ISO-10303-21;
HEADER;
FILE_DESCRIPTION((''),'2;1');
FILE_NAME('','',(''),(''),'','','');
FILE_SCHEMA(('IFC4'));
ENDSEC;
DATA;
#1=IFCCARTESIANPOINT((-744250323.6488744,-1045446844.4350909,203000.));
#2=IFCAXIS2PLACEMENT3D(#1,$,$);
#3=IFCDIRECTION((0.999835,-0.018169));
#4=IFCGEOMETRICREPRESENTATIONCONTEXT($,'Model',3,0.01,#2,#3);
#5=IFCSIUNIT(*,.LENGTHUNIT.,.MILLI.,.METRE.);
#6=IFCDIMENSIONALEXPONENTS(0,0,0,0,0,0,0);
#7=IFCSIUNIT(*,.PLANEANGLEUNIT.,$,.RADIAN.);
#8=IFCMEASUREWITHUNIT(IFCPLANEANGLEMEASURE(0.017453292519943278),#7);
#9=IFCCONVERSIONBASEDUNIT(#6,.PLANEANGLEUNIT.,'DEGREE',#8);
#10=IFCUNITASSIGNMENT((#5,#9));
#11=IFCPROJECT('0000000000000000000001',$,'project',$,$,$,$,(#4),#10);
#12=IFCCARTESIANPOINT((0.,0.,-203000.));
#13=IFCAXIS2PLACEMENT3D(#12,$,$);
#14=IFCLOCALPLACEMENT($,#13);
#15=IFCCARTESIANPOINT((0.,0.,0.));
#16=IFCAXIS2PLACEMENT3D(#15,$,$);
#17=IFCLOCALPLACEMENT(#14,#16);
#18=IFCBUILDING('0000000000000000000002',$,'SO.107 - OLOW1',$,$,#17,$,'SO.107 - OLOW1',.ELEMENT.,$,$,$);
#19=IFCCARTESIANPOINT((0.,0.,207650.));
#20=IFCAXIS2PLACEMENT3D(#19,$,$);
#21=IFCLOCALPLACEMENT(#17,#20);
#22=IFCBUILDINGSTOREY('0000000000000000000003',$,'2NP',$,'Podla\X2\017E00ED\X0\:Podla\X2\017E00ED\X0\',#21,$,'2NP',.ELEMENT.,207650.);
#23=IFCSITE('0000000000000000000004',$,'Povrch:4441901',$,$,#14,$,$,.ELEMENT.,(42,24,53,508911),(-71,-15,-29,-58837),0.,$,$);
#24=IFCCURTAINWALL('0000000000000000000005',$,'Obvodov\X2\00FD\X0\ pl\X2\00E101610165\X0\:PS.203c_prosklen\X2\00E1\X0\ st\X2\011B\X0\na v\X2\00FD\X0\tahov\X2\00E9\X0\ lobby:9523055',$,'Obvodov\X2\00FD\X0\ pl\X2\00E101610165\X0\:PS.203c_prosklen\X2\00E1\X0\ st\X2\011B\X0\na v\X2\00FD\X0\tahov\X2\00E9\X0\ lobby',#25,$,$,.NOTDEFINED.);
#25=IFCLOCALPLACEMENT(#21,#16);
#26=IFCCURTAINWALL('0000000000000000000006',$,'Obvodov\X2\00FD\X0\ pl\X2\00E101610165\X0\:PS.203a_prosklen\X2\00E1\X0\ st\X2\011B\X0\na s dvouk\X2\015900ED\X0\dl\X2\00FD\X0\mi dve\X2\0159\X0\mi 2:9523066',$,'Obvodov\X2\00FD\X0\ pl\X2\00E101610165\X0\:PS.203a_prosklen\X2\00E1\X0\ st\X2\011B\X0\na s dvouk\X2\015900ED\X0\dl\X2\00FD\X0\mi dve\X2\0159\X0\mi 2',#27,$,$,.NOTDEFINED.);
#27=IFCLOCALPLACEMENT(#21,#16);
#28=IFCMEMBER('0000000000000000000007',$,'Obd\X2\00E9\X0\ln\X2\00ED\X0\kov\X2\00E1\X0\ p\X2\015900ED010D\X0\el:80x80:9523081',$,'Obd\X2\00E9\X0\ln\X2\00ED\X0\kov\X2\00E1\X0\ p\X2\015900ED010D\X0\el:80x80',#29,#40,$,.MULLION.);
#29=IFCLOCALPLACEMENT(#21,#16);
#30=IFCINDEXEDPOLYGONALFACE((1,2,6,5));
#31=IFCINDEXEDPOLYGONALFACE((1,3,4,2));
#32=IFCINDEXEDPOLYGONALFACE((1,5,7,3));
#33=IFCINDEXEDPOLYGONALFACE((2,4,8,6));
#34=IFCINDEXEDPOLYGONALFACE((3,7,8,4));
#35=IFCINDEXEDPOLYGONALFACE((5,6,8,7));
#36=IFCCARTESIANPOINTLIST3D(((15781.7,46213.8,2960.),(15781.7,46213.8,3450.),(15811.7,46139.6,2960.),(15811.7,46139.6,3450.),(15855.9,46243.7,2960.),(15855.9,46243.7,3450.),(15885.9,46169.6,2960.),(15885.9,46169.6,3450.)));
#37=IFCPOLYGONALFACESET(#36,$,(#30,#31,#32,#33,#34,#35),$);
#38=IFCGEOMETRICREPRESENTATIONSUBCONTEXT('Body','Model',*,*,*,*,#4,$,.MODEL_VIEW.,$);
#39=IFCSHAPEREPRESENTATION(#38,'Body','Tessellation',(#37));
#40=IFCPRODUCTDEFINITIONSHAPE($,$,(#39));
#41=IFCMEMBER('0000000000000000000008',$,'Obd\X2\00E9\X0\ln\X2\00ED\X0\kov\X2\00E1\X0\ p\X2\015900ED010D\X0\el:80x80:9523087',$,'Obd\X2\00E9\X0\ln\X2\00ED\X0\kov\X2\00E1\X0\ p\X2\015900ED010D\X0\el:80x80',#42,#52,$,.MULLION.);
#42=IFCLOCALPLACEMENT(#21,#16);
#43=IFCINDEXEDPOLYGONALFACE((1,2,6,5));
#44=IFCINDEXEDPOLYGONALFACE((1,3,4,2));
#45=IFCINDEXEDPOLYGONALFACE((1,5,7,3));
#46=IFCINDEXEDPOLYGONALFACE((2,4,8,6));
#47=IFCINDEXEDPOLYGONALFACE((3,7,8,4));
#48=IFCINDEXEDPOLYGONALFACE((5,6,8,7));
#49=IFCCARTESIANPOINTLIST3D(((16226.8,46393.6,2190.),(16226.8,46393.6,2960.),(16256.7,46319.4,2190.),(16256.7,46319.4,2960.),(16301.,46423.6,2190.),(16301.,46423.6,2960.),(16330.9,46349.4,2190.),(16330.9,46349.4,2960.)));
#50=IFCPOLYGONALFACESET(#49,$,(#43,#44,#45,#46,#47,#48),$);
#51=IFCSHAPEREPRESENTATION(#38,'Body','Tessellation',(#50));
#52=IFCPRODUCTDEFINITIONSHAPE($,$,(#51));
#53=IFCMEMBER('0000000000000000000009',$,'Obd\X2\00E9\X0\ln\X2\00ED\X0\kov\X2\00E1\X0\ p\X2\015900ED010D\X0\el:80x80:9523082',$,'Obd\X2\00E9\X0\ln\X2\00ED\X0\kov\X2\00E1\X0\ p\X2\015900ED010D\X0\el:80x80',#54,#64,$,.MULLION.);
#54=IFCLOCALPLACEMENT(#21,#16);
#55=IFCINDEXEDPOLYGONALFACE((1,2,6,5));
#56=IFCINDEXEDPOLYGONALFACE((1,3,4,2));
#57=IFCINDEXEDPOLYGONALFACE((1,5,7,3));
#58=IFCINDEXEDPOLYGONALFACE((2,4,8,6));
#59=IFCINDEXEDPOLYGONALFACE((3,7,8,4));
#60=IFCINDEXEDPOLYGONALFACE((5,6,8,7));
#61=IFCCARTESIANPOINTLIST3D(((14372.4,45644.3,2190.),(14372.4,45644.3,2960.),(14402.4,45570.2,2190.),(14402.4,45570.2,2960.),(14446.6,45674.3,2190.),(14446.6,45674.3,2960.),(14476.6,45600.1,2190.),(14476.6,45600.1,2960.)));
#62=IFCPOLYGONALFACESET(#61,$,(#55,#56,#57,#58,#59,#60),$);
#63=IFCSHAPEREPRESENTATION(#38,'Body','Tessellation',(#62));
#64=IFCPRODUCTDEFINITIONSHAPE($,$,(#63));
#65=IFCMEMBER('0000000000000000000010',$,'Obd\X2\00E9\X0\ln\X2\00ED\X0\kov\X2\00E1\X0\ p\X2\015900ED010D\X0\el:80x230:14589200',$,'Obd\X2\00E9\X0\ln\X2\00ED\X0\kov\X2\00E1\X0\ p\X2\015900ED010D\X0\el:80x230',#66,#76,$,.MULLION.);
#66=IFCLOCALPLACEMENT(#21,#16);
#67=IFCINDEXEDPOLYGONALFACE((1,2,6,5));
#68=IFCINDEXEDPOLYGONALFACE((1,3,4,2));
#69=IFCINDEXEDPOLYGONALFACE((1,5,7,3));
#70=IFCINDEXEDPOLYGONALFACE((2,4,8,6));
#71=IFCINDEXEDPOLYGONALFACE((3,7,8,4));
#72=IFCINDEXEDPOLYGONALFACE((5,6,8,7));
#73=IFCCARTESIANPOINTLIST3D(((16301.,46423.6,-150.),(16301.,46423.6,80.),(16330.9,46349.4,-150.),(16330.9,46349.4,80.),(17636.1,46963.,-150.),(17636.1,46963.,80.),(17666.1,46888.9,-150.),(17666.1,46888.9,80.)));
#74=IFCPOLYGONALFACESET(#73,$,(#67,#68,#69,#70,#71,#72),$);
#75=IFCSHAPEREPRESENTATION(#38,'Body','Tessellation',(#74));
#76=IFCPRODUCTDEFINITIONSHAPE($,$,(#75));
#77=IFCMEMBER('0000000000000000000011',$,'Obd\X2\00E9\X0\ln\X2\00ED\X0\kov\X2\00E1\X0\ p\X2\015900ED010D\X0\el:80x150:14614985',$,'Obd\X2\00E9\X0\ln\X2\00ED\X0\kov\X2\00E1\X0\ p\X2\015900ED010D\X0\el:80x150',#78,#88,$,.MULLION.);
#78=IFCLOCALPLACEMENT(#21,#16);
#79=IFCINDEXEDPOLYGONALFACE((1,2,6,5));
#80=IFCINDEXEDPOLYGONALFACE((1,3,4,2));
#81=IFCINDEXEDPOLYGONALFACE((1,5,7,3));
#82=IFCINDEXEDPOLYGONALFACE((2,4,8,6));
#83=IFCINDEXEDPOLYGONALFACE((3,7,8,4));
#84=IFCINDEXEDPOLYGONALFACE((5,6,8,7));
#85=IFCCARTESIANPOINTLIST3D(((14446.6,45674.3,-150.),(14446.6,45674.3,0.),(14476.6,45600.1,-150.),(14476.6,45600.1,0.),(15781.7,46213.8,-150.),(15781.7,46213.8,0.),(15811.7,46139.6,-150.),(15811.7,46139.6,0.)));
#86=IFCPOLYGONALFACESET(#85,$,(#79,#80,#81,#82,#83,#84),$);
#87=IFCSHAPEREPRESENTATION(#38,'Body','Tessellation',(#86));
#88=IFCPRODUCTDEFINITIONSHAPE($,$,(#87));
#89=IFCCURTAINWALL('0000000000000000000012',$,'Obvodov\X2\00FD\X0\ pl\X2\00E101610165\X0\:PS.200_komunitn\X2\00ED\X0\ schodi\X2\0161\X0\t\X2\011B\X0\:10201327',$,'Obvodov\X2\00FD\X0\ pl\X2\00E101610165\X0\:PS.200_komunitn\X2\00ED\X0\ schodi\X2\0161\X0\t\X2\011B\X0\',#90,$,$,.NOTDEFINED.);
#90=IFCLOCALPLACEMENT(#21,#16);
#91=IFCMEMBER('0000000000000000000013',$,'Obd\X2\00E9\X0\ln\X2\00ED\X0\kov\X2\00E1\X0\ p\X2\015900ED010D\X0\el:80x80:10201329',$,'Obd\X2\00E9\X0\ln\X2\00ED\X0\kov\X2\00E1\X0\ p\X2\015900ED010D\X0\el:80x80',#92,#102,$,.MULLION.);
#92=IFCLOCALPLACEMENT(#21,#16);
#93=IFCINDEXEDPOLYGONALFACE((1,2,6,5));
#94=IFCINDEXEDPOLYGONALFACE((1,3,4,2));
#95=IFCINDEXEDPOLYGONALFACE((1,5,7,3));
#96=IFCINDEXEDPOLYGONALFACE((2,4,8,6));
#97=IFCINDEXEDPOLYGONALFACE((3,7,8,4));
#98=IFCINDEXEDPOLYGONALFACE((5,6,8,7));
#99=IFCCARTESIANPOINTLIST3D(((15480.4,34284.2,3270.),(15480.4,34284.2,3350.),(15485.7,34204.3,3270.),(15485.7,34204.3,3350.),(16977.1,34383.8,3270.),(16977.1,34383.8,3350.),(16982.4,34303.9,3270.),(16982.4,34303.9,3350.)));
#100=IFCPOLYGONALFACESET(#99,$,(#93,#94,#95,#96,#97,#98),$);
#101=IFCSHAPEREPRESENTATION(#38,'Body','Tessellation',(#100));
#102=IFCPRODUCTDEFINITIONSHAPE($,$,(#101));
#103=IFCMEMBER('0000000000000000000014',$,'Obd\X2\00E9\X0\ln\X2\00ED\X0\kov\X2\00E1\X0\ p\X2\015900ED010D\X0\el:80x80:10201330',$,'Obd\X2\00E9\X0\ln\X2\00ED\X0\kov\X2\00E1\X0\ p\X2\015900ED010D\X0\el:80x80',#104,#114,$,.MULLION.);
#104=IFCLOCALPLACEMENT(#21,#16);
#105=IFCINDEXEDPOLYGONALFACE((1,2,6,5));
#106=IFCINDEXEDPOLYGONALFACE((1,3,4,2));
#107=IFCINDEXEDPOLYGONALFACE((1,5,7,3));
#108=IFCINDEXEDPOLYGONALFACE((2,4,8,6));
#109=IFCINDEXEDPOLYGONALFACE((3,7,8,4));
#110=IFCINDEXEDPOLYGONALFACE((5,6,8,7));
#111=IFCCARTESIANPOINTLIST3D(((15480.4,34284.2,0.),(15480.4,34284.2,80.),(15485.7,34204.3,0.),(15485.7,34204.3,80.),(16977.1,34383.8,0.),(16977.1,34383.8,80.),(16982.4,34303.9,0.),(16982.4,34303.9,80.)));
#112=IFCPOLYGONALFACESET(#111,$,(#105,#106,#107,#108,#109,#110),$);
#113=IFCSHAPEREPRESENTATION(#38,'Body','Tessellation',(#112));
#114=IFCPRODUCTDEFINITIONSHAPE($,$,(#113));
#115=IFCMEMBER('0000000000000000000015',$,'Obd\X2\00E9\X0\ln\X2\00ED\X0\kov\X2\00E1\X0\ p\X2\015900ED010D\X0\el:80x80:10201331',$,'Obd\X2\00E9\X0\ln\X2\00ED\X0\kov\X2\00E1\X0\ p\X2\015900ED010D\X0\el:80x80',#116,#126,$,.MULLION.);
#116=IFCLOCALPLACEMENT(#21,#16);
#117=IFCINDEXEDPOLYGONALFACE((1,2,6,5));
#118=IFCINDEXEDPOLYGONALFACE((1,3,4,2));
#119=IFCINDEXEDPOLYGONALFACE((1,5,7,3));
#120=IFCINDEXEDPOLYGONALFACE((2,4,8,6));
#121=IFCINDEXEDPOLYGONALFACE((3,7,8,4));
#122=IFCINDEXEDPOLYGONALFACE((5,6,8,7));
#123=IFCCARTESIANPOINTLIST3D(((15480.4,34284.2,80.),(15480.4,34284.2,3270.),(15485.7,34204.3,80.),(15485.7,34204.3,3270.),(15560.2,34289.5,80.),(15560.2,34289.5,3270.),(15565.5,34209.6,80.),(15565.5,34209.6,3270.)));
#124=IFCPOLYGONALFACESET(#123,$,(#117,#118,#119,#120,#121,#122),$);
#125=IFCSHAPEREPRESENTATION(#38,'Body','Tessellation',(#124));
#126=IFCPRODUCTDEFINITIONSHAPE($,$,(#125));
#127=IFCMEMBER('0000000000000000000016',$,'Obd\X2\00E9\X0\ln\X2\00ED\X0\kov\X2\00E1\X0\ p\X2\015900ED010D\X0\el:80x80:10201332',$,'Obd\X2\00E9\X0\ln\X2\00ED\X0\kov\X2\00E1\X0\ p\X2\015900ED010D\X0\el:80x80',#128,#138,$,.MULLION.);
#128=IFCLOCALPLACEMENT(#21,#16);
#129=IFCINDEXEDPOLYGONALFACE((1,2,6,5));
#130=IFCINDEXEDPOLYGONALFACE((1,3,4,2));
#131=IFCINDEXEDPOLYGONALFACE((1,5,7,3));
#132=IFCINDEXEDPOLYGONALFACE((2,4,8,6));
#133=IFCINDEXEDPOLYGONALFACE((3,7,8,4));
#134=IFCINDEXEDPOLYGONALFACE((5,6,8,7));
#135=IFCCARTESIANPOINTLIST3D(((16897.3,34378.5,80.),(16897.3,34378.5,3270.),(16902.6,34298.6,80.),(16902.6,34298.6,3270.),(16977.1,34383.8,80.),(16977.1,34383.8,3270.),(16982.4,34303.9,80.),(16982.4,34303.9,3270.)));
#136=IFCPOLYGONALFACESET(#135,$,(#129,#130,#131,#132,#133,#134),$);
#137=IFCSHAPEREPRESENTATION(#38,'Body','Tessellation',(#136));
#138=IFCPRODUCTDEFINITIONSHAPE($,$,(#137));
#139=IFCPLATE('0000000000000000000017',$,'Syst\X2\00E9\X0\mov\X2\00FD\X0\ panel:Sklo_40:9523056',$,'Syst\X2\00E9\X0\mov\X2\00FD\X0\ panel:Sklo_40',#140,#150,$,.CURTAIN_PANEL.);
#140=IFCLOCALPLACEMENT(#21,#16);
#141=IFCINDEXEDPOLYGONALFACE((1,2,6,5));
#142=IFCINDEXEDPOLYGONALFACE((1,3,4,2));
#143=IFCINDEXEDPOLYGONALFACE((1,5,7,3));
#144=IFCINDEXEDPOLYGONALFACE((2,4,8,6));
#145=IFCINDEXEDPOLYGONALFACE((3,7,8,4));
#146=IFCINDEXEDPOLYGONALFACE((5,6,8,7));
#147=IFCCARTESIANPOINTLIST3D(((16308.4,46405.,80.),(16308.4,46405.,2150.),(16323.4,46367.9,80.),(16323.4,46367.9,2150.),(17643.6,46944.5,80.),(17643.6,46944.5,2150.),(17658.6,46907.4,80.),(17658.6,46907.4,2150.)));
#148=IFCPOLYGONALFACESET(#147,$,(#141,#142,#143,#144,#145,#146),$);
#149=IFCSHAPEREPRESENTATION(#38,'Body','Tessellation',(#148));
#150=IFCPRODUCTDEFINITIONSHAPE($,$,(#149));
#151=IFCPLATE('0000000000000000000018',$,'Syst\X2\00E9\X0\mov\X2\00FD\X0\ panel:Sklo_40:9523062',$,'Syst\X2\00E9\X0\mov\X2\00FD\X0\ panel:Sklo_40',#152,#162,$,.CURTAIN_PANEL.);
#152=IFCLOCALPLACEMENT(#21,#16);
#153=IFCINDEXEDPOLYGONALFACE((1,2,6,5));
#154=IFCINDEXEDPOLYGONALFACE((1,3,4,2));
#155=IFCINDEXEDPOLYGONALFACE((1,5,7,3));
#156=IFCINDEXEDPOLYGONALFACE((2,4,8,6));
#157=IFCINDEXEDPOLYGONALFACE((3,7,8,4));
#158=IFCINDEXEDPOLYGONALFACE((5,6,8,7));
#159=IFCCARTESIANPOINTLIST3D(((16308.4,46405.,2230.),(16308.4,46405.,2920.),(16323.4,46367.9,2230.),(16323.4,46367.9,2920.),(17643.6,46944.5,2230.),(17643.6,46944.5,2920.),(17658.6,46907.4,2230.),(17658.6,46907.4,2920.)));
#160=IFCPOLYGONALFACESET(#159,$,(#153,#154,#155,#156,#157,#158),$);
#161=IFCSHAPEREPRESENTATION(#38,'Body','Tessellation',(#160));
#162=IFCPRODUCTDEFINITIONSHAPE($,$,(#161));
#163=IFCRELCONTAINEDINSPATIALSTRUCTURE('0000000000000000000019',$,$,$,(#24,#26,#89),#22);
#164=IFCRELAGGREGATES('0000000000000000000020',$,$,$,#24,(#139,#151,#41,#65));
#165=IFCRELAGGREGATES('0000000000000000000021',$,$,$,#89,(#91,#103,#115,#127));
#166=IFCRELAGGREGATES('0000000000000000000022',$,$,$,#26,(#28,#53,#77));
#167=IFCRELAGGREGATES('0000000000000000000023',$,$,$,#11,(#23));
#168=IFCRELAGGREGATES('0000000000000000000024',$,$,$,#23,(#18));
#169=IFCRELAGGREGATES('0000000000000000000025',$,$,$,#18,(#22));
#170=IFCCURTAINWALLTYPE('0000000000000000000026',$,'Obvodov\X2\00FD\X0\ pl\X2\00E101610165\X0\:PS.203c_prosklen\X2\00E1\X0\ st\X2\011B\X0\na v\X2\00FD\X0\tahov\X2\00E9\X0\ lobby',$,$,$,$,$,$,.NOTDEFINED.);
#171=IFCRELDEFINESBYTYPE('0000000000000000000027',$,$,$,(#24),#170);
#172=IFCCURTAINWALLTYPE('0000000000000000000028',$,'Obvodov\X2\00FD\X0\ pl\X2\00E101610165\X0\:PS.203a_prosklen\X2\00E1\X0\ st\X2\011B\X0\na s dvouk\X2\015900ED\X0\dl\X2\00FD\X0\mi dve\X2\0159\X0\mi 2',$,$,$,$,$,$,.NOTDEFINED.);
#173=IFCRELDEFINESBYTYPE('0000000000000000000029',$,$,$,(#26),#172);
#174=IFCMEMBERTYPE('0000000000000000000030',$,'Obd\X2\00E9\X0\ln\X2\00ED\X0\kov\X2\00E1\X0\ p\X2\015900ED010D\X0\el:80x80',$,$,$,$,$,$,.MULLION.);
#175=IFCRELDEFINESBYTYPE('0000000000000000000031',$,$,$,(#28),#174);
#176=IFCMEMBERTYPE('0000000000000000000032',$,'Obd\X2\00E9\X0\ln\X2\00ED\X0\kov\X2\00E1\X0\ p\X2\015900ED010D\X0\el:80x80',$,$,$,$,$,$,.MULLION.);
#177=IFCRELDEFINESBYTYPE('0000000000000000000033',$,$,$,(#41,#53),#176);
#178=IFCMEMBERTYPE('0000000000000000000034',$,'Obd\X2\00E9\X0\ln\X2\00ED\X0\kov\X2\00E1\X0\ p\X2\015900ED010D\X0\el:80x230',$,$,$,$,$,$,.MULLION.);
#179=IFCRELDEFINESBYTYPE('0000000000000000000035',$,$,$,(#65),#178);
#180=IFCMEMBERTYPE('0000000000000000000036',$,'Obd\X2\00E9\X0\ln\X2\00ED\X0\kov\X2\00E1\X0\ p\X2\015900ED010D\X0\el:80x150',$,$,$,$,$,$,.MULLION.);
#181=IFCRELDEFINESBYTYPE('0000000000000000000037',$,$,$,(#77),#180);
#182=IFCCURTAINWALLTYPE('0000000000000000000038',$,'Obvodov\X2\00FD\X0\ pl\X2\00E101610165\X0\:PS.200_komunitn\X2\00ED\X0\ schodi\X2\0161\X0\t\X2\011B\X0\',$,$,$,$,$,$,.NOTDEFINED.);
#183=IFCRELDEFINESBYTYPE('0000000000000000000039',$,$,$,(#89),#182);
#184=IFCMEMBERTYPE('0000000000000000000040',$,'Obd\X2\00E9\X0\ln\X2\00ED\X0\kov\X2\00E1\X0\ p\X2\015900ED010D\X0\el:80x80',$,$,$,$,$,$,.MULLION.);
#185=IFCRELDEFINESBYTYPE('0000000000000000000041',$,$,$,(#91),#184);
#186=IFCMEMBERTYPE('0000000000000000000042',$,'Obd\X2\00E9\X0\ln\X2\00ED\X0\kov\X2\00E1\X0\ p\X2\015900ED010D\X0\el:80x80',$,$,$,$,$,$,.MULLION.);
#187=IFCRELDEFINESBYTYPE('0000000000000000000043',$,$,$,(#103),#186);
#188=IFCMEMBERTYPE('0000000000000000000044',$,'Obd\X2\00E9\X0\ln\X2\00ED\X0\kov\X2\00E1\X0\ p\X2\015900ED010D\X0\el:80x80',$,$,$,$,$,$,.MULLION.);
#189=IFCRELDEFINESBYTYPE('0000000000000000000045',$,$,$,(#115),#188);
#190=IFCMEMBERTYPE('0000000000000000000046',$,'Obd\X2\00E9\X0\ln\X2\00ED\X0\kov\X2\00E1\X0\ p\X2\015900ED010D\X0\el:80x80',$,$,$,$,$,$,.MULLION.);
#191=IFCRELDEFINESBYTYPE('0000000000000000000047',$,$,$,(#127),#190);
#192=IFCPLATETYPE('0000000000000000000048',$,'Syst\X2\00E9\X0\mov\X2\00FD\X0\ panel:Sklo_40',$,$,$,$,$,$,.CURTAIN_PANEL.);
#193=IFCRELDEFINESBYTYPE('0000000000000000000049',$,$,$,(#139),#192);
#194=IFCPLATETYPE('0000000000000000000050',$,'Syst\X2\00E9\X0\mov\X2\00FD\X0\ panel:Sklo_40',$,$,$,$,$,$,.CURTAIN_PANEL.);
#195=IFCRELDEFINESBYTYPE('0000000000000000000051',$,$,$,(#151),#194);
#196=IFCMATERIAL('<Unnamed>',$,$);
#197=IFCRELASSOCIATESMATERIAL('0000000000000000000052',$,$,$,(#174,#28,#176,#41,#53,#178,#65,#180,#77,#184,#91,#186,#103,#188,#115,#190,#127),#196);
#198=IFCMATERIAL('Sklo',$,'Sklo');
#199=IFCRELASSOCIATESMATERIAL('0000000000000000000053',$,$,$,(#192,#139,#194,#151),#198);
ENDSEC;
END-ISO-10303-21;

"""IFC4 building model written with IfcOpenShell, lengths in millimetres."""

from ifc_helpers import new_model, entity, si_unit, converted_unit, direction, frame, origin, place, context, subcontext, project, spatial, indexed_curve, outline, extrude, source, transform, mapped, material, type_object, type_shapes, element, aggregate, save


model = new_model("IFC4")

# Units and contexts
model_context = context("Model", 3, precision=0.01, world=frame((-744250323.6488744, -1045446844.4350909, 203000.0)), true_north=direction((0.999835, -0.018169)))
body_context = subcontext(model_context, "Body", "Model", "MODEL_VIEW")
ifc_project = project(units=[si_unit("LENGTHUNIT", "METRE", prefix="MILLI"), converted_unit("PLANEANGLEUNIT", "DEGREE", entity("IfcPlaneAngleMeasure", 0.017453292519943278), si_unit("PLANEANGLEUNIT", "RADIAN"), dimensions=[0, 0, 0, 0, 0, 0, 0])], contexts=[model_context])

# Site, building, storey
site_placement = place(None, frame((0.0, 0.0, -203000.0)))
site = spatial("IfcSite", under=ifc_project, at=site_placement, Name="Povrch:4441901", CompositionType="ELEMENT", RefLatitude=(42, 24, 53, 508911), RefLongitude=(-71, -15, -29, -58837), RefElevation=0.0)
building_placement = place(site_placement, origin())
building = spatial("IfcBuilding", under=site, at=building_placement, Name="SO.107 - OLOW1", LongName="SO.107 - OLOW1", CompositionType="ELEMENT")
storey_placement = place(building_placement, frame((0.0, 0.0, 207650.0)))
storey = spatial("IfcBuildingStorey", under=building, at=storey_placement, Name="2NP", ObjectType="Podlaží:Podlaží", LongName="2NP", CompositionType="ELEMENT", Elevation=207650.0)

# Curtain wall
curtain_wall_type_1 = type_object("IfcCurtainWallType", Name="Obvodový plášť:PS.203c_prosklená stěna výtahové lobby", PredefinedType="NOTDEFINED")
curtain_wall_1_placement = place(storey_placement, frame((0.0, 0.0, -207650.0)))
curtain_wall_1 = element("IfcCurtainWall", 1, at=curtain_wall_1_placement, inside=storey, type_object=curtain_wall_type_1, Name="Obvodový plášť:PS.203c_prosklená stěna výtahové lobby:9523055", ObjectType="Obvodový plášť:PS.203c_prosklená stěna výtahové lobby", PredefinedType="NOTDEFINED")
ifc_material_1 = material(Name="<Unnamed>")

# Curtain wall
curtain_wall_type_2 = type_object("IfcCurtainWallType", Name="Obvodový plášť:PS.203a_prosklená stěna s dvoukřídlými dveřmi 2", PredefinedType="NOTDEFINED")
curtain_wall_2_placement = place(storey_placement, frame((0.0, 0.0, -207650.0)))
curtain_wall_2 = element("IfcCurtainWall", 2, at=curtain_wall_2_placement, inside=storey, type_object=curtain_wall_type_2, Name="Obvodový plášť:PS.203a_prosklená stěna s dvoukřídlými dveřmi 2:9523066", ObjectType="Obvodový plášť:PS.203a_prosklená stěna s dvoukřídlými dveřmi 2", PredefinedType="NOTDEFINED")

# Members
member_type_1 = type_object("IfcMemberType", Name="Obdélníková příčel:80x80", PredefinedType="MULLION", material=ifc_material_1)
shared_shape_1 = source(origin(), body_context, "Body", "SweptSolid", [
    extrude(outline(indexed_curve([(-40.0, -40.0), (40.0, -40.0), (40.0, 40.0), (-40.0, 40.0), (-40.0, -40.0)], self_intersect=False)), frame((-40.0, 0.0, -490.0), z_axis=(0.0, 0.0, 1.0), x_axis=(-1.0, 0.0, 0.0)), (0.0, 0.0, 1.0), 490.0),
])
type_shapes(member_type_1, [shared_shape_1])
member_1_placement = place(curtain_wall_2_placement, frame((15870.9, 46206.7, 210610.0), z_axis=(0.0, 0.0, -1.0), x_axis=(0.927176, 0.374626, 0.0)))
member_1 = element("IfcMember", 3, at=member_1_placement, type_object=member_type_1, material=ifc_material_1, Name="Obdélníková příčel:80x80:9523081", ObjectType="Obdélníková příčel:80x80", PredefinedType="MULLION", context=body_context, shape_type="MappedRepresentation", body=[
    mapped(shared_shape_1, transform((0.0, 0.0, 0.0), scale=1.0)),
])
member_type_2 = type_object("IfcMemberType", Name="Obdélníková příčel:80x80", PredefinedType="MULLION", material=ifc_material_1)
shared_shape_2 = source(origin(), body_context, "Body", "SweptSolid", [
    extrude(outline(indexed_curve([(-40.0, -40.0), (40.0, -40.0), (40.0, 40.0), (-40.0, 40.0), (-40.0, -40.0)], self_intersect=False)), frame((-40.0, 0.0, -770.0), z_axis=(0.0, 0.0, 1.0), x_axis=(-1.0, 0.0, 0.0)), (0.0, 0.0, 1.0), 770.0),
])
type_shapes(member_type_2, [shared_shape_2])
member_2_placement = place(curtain_wall_1_placement, frame((16241.8, 46356.5, 210610.0), z_axis=(0.0, 0.0, 1.0), x_axis=(-0.927176, -0.374626, 0.0)))
member_2 = element("IfcMember", 4, at=member_2_placement, type_object=member_type_2, material=ifc_material_1, Name="Obdélníková příčel:80x80:9523087", ObjectType="Obdélníková příčel:80x80", PredefinedType="MULLION", context=body_context, shape_type="MappedRepresentation", body=[
    mapped(shared_shape_2, transform((0.0, 0.0, 0.0), scale=1.0)),
])
member_3_placement = place(curtain_wall_2_placement, frame((14387.4, 45607.3, 210610.0), z_axis=(0.0, 0.0, 1.0), x_axis=(-0.927176, -0.374626, 0.0)))
member_3 = element("IfcMember", 5, at=member_3_placement, type_object=member_type_2, material=ifc_material_1, Name="Obdélníková příčel:80x80:9523082", ObjectType="Obdélníková příčel:80x80", PredefinedType="MULLION", context=body_context, shape_type="MappedRepresentation", body=[
    mapped(shared_shape_2, transform((0.0, 0.0, 0.0), scale=1.0)),
])
member_type_3 = type_object("IfcMemberType", Name="Obdélníková příčel:80x230", PredefinedType="MULLION", material=ifc_material_1)
shared_shape_3 = source(origin(), body_context, "Body", "SweptSolid", [
    extrude(outline(indexed_curve([(-115.0, -40.0), (115.0, -40.0), (115.0, 40.0), (-115.0, 40.0), (-115.0, -40.0)], self_intersect=False)), frame((-115.0, 0.0, -1440.0), z_axis=(0.0, 0.0, 1.0), x_axis=(-1.0, 0.0, 0.0)), (0.0, 0.0, 1.0), 1440.0),
])
type_shapes(member_type_3, [shared_shape_3])
member_4_placement = place(curtain_wall_1_placement, frame((16315.9, 46386.5, 207500.0), z_axis=(-0.927176, -0.374626, 0.0), x_axis=(0.0, 0.0, -1.0)))
member_4 = element("IfcMember", 6, at=member_4_placement, type_object=member_type_3, material=ifc_material_1, Name="Obdélníková příčel:80x230:14589200", ObjectType="Obdélníková příčel:80x230", PredefinedType="MULLION", context=body_context, shape_type="MappedRepresentation", body=[
    mapped(shared_shape_3, transform((0.0, 0.0, 0.0), scale=1.0)),
])
member_type_4 = type_object("IfcMemberType", Name="Obdélníková příčel:80x150", PredefinedType="MULLION", material=ifc_material_1)
shared_shape_4 = source(origin(), body_context, "Body", "SweptSolid", [
    extrude(outline(indexed_curve([(-75.0, -40.0), (75.0, -40.0), (75.0, 40.0), (-75.0, 40.0), (-75.0, -40.0)], self_intersect=False)), frame((-75.0, 0.0, -1440.0), z_axis=(0.0, 0.0, 1.0), x_axis=(-1.0, 0.0, 0.0)), (0.0, 0.0, 1.0), 1440.0),
])
type_shapes(member_type_4, [shared_shape_4])
member_5_placement = place(curtain_wall_2_placement, frame((14461.6, 45637.2, 207500.0), z_axis=(-0.927176, -0.374626, 0.0), x_axis=(0.0, 0.0, -1.0)))
member_5 = element("IfcMember", 7, at=member_5_placement, type_object=member_type_4, material=ifc_material_1, Name="Obdélníková příčel:80x150:14614985", ObjectType="Obdélníková příčel:80x150", PredefinedType="MULLION", context=body_context, shape_type="MappedRepresentation", body=[
    mapped(shared_shape_4, transform((0.0, 0.0, 0.0), scale=1.0)),
])

# Curtain wall, members
curtain_wall_type_3 = type_object("IfcCurtainWallType", Name="Obvodový plášť:PS.200_komunitní schodiště", PredefinedType="NOTDEFINED")
curtain_wall_3_placement = place(storey_placement, frame((0.0, 0.0, -207650.0)))
curtain_wall_3 = element("IfcCurtainWall", 8, at=curtain_wall_3_placement, inside=storey, type_object=curtain_wall_type_3, Name="Obvodový plášť:PS.200_komunitní schodiště:10201327", ObjectType="Obvodový plášť:PS.200_komunitní schodiště", PredefinedType="NOTDEFINED")
member_type_5 = type_object("IfcMemberType", Name="Obdélníková příčel:80x80", PredefinedType="MULLION", material=ifc_material_1)
shared_shape_5 = source(origin(), body_context, "Body", "SweptSolid", [
    extrude(outline(indexed_curve([(-40.0, -40.0), (40.0, -40.0), (40.0, 40.0), (-40.0, 40.0), (-40.0, -40.0)], self_intersect=False)), frame((-40.0, 0.0, -1500.0), z_axis=(0.0, 0.0, 1.0), x_axis=(-1.0, 0.0, 0.0)), (0.0, 0.0, 1.0), 1500.0),
])
type_shapes(member_type_5, [shared_shape_5])
member_6_placement = place(curtain_wall_3_placement, frame((15483.0, 34244.2, 211000.0), z_axis=(-0.997792, -0.066409, 0.0), x_axis=(0.0, 0.0, 1.0)))
member_6 = element("IfcMember", 9, at=member_6_placement, type_object=member_type_5, material=ifc_material_1, Name="Obdélníková příčel:80x80:10201329", ObjectType="Obdélníková příčel:80x80", PredefinedType="MULLION", context=body_context, shape_type="MappedRepresentation", body=[
    mapped(shared_shape_5, transform((0.0, 0.0, 0.0), scale=1.0)),
])
member_type_6 = type_object("IfcMemberType", Name="Obdélníková příčel:80x80", PredefinedType="MULLION", material=ifc_material_1)
shared_shape_6 = source(origin(), body_context, "Body", "SweptSolid", [
    extrude(outline(indexed_curve([(-40.0, -40.0), (40.0, -40.0), (40.0, 40.0), (-40.0, 40.0), (-40.0, -40.0)], self_intersect=False)), frame((-40.0, 0.0, -1500.0), z_axis=(0.0, 0.0, 1.0), x_axis=(-1.0, 0.0, 0.0)), (0.0, 0.0, 1.0), 1500.0),
])
type_shapes(member_type_6, [shared_shape_6])
member_7_placement = place(curtain_wall_3_placement, frame((16979.7, 34343.9, 207650.0), z_axis=(0.997792, 0.066409, 0.0), x_axis=(0.0, 0.0, -1.0)))
member_7 = element("IfcMember", 10, at=member_7_placement, type_object=member_type_6, material=ifc_material_1, Name="Obdélníková příčel:80x80:10201330", ObjectType="Obdélníková příčel:80x80", PredefinedType="MULLION", context=body_context, shape_type="MappedRepresentation", body=[
    mapped(shared_shape_6, transform((0.0, 0.0, 0.0), scale=1.0)),
])
member_type_7 = type_object("IfcMemberType", Name="Obdélníková příčel:80x80", PredefinedType="MULLION", material=ifc_material_1)
shared_shape_7 = source(origin(), body_context, "Body", "SweptSolid", [
    extrude(outline(indexed_curve([(-40.0, -40.0), (40.0, -40.0), (40.0, 40.0), (-40.0, 40.0), (-40.0, -40.0)], self_intersect=False)), frame((-40.0, 0.0, -3190.0), z_axis=(0.0, 0.0, 1.0), x_axis=(-1.0, 0.0, 0.0)), (0.0, 0.0, 1.0), 3190.0),
])
type_shapes(member_type_7, [shared_shape_7])
member_8_placement = place(curtain_wall_3_placement, frame((15483.0, 34244.2, 207730.0), z_axis=(0.0, 0.0, -1.0), x_axis=(-0.997792, -0.066409, 0.0)))
member_8 = element("IfcMember", 11, at=member_8_placement, type_object=member_type_7, material=ifc_material_1, Name="Obdélníková příčel:80x80:10201331", ObjectType="Obdélníková příčel:80x80", PredefinedType="MULLION", context=body_context, shape_type="MappedRepresentation", body=[
    mapped(shared_shape_7, transform((0.0, 0.0, 0.0), scale=1.0)),
])
member_type_8 = type_object("IfcMemberType", Name="Obdélníková příčel:80x80", PredefinedType="MULLION", material=ifc_material_1)
shared_shape_8 = source(origin(), body_context, "Body", "SweptSolid", [
    extrude(outline(indexed_curve([(-40.0, -40.0), (40.0, -40.0), (40.0, 40.0), (-40.0, 40.0), (-40.0, -40.0)], self_intersect=False)), frame((-40.0, 0.0, -3190.0), z_axis=(0.0, 0.0, 1.0), x_axis=(-1.0, 0.0, 0.0)), (0.0, 0.0, 1.0), 3190.0),
])
type_shapes(member_type_8, [shared_shape_8])
member_9_placement = place(curtain_wall_3_placement, frame((16979.7, 34343.9, 210920.0), z_axis=(0.0, 0.0, 1.0), x_axis=(0.997792, 0.066409, 0.0)))
member_9 = element("IfcMember", 12, at=member_9_placement, type_object=member_type_8, material=ifc_material_1, Name="Obdélníková příčel:80x80:10201332", ObjectType="Obdélníková příčel:80x80", PredefinedType="MULLION", context=body_context, shape_type="MappedRepresentation", body=[
    mapped(shared_shape_8, transform((0.0, 0.0, 0.0), scale=1.0)),
])

# Plates
ifc_material_2 = material(Name="Sklo", Category="Sklo")
plate_type_1 = type_object("IfcPlateType", Name="Systémový panel:Sklo_40", PredefinedType="CURTAIN_PANEL", material=ifc_material_2)
shared_shape_9 = source(origin(), body_context, "Body", "SweptSolid", [
    extrude(outline(indexed_curve([(-20.0, -720.0), (20.0, -720.0), (20.0, 720.0), (-20.0, 720.0), (-20.0, -720.0)], self_intersect=False)), frame((0.0, 0.0, 0.0), z_axis=(0.0, 0.0, 1.0), x_axis=(0.0, 1.0, 0.0)), (0.0, 0.0, 1.0), 2070.0),
])
type_shapes(plate_type_1, [shared_shape_9])
plate_1_placement = place(curtain_wall_1_placement, frame((16983.5, 46656.2, 207730.0), z_axis=(0.0, 0.0, 1.0), x_axis=(0.927176, 0.374626, 0.0)))
plate_1 = element("IfcPlate", 13, at=plate_1_placement, type_object=plate_type_1, material=ifc_material_2, Name="Systémový panel:Sklo_40:9523056", ObjectType="Systémový panel:Sklo_40", PredefinedType="CURTAIN_PANEL", context=body_context, shape_type="MappedRepresentation", body=[
    mapped(shared_shape_9, transform((0.0, 0.0, 0.0), scale=1.0)),
])
plate_type_2 = type_object("IfcPlateType", Name="Systémový panel:Sklo_40", PredefinedType="CURTAIN_PANEL", material=ifc_material_2)
shared_shape_10 = source(origin(), body_context, "Body", "SweptSolid", [
    extrude(outline(indexed_curve([(-20.0, -720.0), (20.0, -720.0), (20.0, 720.0), (-20.0, 720.0), (-20.0, -720.0)], self_intersect=False)), frame((0.0, 0.0, 0.0), z_axis=(0.0, 0.0, 1.0), x_axis=(0.0, 1.0, 0.0)), (0.0, 0.0, 1.0), 690.0),
])
type_shapes(plate_type_2, [shared_shape_10])
plate_2_placement = place(curtain_wall_1_placement, frame((16983.5, 46656.2, 209880.0), z_axis=(0.0, 0.0, 1.0), x_axis=(0.927176, 0.374626, 0.0)))
plate_2 = element("IfcPlate", 14, at=plate_2_placement, type_object=plate_type_2, material=ifc_material_2, Name="Systémový panel:Sklo_40:9523062", ObjectType="Systémový panel:Sklo_40", PredefinedType="CURTAIN_PANEL", context=body_context, shape_type="MappedRepresentation", body=[
    mapped(shared_shape_10, transform((0.0, 0.0, 0.0), scale=1.0)),
])
aggregate(curtain_wall_1, [plate_1, plate_2, member_2, member_4])

aggregate(curtain_wall_3, [member_6, member_7, member_8, member_9])

aggregate(curtain_wall_2, [member_1, member_3, member_5])

save(model, "model.ifc")
